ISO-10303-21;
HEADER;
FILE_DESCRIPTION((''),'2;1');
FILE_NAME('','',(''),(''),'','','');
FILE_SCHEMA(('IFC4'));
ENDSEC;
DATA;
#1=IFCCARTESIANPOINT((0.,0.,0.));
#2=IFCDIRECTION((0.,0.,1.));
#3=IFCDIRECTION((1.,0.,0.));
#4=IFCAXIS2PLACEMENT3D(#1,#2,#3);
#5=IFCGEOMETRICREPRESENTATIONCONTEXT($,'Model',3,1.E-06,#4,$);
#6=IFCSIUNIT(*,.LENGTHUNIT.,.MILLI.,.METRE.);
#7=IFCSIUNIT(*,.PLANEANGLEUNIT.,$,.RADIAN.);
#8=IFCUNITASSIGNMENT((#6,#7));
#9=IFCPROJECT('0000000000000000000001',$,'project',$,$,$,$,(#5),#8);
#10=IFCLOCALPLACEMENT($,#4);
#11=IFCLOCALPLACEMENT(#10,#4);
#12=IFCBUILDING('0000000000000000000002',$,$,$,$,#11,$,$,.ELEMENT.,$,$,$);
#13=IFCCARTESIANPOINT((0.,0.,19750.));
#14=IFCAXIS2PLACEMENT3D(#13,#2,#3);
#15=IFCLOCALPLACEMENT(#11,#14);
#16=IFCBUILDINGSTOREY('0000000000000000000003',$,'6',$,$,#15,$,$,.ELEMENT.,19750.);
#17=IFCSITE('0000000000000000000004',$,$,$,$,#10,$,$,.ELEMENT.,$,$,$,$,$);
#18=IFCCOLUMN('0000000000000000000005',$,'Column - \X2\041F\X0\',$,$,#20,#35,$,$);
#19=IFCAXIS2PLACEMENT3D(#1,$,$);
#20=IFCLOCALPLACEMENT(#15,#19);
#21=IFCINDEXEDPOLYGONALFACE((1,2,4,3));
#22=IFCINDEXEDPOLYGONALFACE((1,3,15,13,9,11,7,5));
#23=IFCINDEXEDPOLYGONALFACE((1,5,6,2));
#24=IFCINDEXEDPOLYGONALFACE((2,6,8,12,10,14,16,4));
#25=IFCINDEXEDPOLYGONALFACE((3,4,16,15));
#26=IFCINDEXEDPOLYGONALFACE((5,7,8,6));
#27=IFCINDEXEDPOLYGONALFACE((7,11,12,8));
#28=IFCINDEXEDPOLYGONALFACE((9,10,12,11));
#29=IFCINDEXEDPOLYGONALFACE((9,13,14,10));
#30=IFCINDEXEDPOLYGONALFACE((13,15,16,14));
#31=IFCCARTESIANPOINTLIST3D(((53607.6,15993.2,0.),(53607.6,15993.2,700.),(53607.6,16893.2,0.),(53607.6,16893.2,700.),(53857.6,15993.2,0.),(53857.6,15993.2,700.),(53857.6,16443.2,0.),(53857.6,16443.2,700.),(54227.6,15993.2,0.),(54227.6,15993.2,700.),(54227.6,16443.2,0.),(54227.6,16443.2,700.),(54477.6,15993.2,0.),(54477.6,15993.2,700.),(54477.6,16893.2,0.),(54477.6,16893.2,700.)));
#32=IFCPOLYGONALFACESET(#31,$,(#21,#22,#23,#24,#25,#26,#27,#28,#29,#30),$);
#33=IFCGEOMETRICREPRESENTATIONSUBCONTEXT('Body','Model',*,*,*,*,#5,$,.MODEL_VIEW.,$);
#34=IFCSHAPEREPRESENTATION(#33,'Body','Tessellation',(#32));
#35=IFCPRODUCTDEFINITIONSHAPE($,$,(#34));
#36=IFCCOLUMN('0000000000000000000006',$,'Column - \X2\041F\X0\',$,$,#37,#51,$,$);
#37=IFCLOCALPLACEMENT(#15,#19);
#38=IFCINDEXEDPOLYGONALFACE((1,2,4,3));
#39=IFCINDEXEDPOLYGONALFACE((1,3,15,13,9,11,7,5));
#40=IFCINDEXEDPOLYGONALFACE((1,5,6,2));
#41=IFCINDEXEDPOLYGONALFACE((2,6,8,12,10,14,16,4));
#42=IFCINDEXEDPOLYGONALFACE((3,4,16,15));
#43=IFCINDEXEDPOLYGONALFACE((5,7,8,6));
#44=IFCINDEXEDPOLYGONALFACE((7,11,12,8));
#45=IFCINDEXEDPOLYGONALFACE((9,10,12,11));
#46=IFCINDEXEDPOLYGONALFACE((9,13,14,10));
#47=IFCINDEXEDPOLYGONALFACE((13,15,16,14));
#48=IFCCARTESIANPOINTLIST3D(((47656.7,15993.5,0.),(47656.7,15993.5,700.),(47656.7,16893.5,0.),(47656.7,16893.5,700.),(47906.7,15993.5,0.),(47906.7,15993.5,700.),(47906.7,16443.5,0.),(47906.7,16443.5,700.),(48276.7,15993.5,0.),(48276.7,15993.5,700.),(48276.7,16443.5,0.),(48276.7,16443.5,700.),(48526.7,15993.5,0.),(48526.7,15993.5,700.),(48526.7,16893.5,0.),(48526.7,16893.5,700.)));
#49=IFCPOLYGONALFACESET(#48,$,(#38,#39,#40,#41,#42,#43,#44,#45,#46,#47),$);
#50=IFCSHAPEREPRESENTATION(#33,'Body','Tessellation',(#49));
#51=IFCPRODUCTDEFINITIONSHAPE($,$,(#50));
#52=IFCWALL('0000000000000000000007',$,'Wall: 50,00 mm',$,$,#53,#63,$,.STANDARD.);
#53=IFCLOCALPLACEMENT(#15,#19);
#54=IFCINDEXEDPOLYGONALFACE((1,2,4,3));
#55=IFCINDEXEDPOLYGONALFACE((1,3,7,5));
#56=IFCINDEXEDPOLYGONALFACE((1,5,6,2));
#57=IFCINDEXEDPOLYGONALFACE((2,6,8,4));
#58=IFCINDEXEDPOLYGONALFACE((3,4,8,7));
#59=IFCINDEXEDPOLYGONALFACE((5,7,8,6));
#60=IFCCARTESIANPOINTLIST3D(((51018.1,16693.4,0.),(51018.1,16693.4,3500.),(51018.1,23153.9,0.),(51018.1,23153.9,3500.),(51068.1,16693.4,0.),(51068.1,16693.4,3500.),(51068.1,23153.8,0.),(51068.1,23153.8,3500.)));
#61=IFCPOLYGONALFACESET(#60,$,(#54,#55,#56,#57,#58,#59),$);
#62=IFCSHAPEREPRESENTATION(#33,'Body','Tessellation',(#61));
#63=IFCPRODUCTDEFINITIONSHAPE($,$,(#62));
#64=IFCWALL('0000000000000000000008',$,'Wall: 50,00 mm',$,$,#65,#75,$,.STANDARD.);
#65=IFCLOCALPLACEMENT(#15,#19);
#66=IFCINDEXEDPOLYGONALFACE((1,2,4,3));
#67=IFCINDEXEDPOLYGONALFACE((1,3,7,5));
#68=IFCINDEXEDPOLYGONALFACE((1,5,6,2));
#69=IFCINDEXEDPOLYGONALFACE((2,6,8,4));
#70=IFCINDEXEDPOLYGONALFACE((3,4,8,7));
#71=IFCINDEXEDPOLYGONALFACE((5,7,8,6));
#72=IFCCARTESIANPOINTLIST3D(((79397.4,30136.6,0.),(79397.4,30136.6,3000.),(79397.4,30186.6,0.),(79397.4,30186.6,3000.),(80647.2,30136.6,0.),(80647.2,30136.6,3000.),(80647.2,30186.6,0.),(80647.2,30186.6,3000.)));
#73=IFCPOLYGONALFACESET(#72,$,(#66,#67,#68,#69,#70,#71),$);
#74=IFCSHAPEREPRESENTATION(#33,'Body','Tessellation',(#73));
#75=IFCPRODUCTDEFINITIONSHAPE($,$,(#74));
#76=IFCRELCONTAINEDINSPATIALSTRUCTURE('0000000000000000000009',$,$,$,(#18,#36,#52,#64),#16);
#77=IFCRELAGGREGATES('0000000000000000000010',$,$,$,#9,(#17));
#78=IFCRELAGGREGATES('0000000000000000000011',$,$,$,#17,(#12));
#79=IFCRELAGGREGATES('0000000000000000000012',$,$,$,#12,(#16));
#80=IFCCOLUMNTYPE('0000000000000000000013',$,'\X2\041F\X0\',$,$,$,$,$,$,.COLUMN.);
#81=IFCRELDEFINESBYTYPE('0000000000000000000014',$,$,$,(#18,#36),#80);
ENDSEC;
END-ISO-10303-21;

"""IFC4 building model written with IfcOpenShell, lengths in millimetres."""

from ifc_helpers import new_model, si_unit, frame, origin_with_axes, place, context, subcontext, project, spatial, line, indexed_curve, outline, extrude, source, transform, mapped, type_object, element, save


model = new_model("IFC4")

# Units and contexts
model_context = context("Model", 3, precision=1e-06, world=origin_with_axes())
body_context = subcontext(model_context, "Body", "Model", "MODEL_VIEW")
ifc_project = project(units=[si_unit("LENGTHUNIT", "METRE", prefix="MILLI"), si_unit("PLANEANGLEUNIT", "RADIAN")], contexts=[model_context])

# Site, building, storey
site_placement = place(None, origin_with_axes())
site = spatial("IfcSite", under=ifc_project, at=site_placement, CompositionType="ELEMENT")
building_placement = place(site_placement, origin_with_axes())
building = spatial("IfcBuilding", under=site, at=building_placement, CompositionType="ELEMENT")
storey_placement = place(building_placement, frame((0.0, 0.0, 19750.0), z_axis=(0.0, 0.0, 1.0), x_axis=(1.0, 0.0, 0.0)))
storey = spatial("IfcBuildingStorey", under=building, at=storey_placement, Name="6", CompositionType="ELEMENT", Elevation=19750.0)

# Columns
column_type = type_object("IfcColumnType", Name="П", PredefinedType="COLUMN")
shared_shape = source(origin_with_axes(), body_context, "Body", "SweptSolid", [
    extrude(outline(indexed_curve([(-450.0, -435.0), (450.0, -435.0), (450.0, -185.0), (0.0, -185.0), (0.0, 185.0), (450.0, 185.0), (450.0, 435.0), (-450.0, 435.0)], segments=[line(1, 2), line(2, 3), line(3, 4), line(4, 5), line(5, 6), line(6, 7), line(7, 8), line(8, 1)])), origin_with_axes(), (0.0, 0.0, 1.0), 700.0),
])
for number, where, z_axis, x_axis, name in (
    (1, (54042.6, 16443.2, 0.0), (0.0, 0.0, 1.0), (0.0, -1.0, 0.0), "Column - П"),
    (2, (48091.7, 16443.5, 0.0), (0.0, 0.0, 1.0), (0.0, -1.0, 0.0), "Column - П"),
):
    element("IfcColumn", number, at=place(storey_placement, frame(where, z_axis=z_axis, x_axis=x_axis)), inside=storey, type_object=column_type, Name=name, context=body_context, shape_type="MappedRepresentation", body=[
        mapped(shared_shape, transform((0.0, 0.0, 0.0), x_axis=(1.0, 0.0, 0.0), y_axis=(0.0, 1.0, 0.0), z_axis=(0.0, 0.0, 1.0), scale=1.0)),
    ])

# Walls
wall_1_placement = place(storey_placement, frame((51043.1, 16693.4, 0.0), z_axis=(0.0, 0.0, 1.0), x_axis=(0.0, 1.0, 0.0)))
element("IfcWall", 3, at=wall_1_placement, inside=storey, Name="Wall: 50,00 mm", PredefinedType="STANDARD", context=body_context, shape_type="SweptSolid", body=[
    extrude(outline(indexed_curve([(0.0, -25.0), (6460.5, -25.0), (6460.6, 25.0), (0.0, 25.0)], segments=[line(1, 2), line(2, 3), line(3, 4), line(4, 1)])), origin_with_axes(), (0.0, 0.0, 1.0), 3500.0),
])
wall_2_placement = place(storey_placement, frame((79397.4, 30161.6, 0.0), z_axis=(0.0, 0.0, 1.0), x_axis=(1.0, 0.0, 0.0)))
element("IfcWall", 4, at=wall_2_placement, inside=storey, Name="Wall: 50,00 mm", PredefinedType="STANDARD", context=body_context, shape_type="SweptSolid", body=[
    extrude(outline(indexed_curve([(0.0, -25.0), (1249.8, -25.0), (1249.8, 25.0), (0.0, 25.0)], segments=[line(1, 2), line(2, 3), line(3, 4), line(4, 1)])), origin_with_axes(), (0.0, 0.0, 1.0), 3000.0),
])

save(model, "model.ifc")
